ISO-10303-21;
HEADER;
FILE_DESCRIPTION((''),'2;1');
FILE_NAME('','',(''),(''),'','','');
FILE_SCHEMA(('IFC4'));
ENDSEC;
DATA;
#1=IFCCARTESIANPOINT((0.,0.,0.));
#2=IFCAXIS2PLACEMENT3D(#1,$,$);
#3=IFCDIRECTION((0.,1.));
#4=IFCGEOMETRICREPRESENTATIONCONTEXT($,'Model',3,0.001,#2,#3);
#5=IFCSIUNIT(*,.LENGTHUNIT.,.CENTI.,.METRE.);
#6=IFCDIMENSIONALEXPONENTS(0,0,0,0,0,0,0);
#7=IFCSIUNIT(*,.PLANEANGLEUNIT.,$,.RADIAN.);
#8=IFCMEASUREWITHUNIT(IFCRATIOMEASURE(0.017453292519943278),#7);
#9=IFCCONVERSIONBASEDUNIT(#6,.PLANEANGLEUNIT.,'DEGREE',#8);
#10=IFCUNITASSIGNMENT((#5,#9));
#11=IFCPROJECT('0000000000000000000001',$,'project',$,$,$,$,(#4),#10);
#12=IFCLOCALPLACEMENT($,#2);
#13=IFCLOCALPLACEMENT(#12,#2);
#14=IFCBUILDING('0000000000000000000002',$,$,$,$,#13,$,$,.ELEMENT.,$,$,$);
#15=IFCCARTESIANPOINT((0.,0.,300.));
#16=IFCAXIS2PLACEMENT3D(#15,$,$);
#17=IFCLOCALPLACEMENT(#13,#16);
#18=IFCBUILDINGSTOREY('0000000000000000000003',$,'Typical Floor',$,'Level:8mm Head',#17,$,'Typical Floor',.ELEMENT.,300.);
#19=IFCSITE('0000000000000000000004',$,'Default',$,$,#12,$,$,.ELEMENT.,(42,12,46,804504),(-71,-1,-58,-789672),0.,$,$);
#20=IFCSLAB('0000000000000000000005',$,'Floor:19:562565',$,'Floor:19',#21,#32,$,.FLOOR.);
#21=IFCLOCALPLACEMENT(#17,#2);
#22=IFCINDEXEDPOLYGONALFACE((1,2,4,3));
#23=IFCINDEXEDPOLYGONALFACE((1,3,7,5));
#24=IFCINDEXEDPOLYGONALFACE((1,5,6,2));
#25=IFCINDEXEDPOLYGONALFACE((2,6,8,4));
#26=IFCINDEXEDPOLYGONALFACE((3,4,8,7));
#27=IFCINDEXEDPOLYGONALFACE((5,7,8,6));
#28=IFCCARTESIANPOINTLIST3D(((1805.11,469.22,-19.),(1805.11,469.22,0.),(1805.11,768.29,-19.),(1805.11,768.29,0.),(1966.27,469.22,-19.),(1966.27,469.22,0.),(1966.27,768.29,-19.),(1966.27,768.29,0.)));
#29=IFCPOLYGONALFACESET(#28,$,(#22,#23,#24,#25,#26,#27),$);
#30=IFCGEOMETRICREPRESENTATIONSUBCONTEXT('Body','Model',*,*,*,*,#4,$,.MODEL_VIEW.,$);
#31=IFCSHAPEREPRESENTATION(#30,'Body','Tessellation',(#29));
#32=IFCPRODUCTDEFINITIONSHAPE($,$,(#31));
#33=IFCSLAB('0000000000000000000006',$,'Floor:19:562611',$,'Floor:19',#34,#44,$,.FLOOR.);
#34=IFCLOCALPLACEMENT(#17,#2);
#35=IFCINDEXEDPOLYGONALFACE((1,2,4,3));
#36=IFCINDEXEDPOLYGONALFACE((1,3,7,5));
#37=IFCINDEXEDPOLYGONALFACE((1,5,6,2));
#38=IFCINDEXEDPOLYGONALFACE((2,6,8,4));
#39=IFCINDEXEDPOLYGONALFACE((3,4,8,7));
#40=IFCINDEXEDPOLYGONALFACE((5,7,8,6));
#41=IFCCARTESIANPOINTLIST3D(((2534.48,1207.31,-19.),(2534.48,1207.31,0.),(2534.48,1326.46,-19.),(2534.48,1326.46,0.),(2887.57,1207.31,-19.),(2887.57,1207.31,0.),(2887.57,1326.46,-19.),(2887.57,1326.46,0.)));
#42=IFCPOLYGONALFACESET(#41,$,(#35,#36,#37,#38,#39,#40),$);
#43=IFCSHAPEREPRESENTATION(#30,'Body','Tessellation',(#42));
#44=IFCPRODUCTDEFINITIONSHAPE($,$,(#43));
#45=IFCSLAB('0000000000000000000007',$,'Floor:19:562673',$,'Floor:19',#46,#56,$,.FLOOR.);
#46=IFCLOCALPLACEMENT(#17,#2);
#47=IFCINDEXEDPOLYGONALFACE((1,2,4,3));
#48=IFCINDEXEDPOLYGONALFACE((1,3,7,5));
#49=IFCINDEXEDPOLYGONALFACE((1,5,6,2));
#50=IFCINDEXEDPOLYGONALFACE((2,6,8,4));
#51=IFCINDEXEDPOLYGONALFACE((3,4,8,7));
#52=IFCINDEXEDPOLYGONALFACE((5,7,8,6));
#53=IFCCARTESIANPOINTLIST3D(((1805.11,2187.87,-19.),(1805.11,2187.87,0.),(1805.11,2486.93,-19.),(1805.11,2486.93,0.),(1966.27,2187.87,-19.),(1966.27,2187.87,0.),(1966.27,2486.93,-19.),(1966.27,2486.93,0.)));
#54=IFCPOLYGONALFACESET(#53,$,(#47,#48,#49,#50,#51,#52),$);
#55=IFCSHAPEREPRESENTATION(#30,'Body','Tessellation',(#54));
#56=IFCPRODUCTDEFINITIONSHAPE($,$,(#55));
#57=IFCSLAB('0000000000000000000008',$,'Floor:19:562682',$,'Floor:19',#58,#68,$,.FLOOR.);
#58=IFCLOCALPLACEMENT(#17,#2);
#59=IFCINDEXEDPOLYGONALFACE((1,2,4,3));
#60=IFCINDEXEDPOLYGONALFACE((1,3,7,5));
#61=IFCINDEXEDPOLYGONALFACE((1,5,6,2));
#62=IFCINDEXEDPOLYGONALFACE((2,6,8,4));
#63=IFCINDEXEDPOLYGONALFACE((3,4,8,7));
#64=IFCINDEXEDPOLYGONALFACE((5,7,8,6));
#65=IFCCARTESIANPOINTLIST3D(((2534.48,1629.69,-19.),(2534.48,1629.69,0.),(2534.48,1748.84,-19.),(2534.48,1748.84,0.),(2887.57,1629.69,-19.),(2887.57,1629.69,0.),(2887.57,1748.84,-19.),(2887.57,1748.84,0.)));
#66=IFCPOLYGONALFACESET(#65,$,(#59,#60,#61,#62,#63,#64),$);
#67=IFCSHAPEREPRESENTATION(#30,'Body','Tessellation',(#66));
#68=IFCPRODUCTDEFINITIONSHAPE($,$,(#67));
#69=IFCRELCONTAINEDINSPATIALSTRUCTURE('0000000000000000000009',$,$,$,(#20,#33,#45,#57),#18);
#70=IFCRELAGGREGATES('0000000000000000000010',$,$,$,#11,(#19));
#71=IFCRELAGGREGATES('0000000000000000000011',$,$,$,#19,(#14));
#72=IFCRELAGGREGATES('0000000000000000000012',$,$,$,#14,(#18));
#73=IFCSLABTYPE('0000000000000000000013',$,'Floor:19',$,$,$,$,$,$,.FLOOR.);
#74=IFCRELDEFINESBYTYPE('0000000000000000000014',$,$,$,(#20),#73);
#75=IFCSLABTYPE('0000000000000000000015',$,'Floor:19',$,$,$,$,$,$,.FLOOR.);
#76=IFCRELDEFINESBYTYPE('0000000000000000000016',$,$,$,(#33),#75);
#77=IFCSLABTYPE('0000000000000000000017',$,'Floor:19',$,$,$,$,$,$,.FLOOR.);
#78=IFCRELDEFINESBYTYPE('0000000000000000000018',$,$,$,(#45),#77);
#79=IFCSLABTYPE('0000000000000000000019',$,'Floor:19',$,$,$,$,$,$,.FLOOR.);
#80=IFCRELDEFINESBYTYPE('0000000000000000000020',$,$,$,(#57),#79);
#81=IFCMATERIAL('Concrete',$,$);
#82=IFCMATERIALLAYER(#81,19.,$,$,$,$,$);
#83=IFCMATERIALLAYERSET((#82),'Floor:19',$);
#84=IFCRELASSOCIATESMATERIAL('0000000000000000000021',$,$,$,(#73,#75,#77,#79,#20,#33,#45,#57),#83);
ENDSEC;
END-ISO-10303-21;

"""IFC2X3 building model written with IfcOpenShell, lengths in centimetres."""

from ifc_helpers import new_model, entity, si_unit, converted_unit, direction, frame, frame_2d, origin, place, context, subcontext, project, spatial, rectangle, extrude, material, layer, layer_set, layer_usage, type_object, element, save


model = new_model("IFC2X3")

# Units and contexts
model_context = context("Model", 3, precision=0.001, world=origin(), true_north=direction((0.0, 1.0)))
body_context = subcontext(model_context, "Body", "Model", "MODEL_VIEW")
ifc_project = project(units=[si_unit("LENGTHUNIT", "METRE", prefix="CENTI"), converted_unit("PLANEANGLEUNIT", "DEGREE", entity("IfcRatioMeasure", 0.017453292519943278), si_unit("PLANEANGLEUNIT", "RADIAN"), dimensions=[0, 0, 0, 0, 0, 0, 0])], contexts=[model_context])

# Site, building, storey
site_placement = place(None, origin())
site = spatial("IfcSite", under=ifc_project, at=site_placement, Name="Default", CompositionType="ELEMENT", RefLatitude=(42, 12, 46, 804504), RefLongitude=(-71, -1, -58, -789672), RefElevation=0.0)
building_placement = place(site_placement, origin())
building = spatial("IfcBuilding", under=site, at=building_placement, CompositionType="ELEMENT")
storey_placement = place(building_placement, frame((0.0, 0.0, 300.0)))
storey = spatial("IfcBuildingStorey", under=building, at=storey_placement, Name="Typical Floor", ObjectType="Level:8mm Head", LongName="Typical Floor", CompositionType="ELEMENT", Elevation=300.0)

# Shared definitions
ifc_material = material(Name="Concrete")

# Slabs
ifc_layer = layer(ifc_material, 19.0)
ifc_layer_set = layer_set([ifc_layer], Name="Floor:19")
ifc_layer_usage_1 = layer_usage(ifc_layer_set, "AXIS3", "POSITIVE", 0.0)
slab_type_1 = type_object("IfcSlabType", Name="Floor:19", PredefinedType="FLOOR", material=ifc_layer_set)
slab_1_placement = place(storey_placement, origin())
element("IfcSlab", 1, at=slab_1_placement, inside=storey, type_object=slab_type_1, material=ifc_layer_usage_1, Name="Floor:19:562565", ObjectType="Floor:19", PredefinedType="FLOOR", context=body_context, shape_type="SweptSolid", body=[
    extrude(rectangle(XDim=299.06, YDim=161.15, at=frame_2d((0.0, 0.0), x_axis=(1.0, 0.0))), frame((1885.69, 618.75, 0.0), z_axis=(0.0, 0.0, -1.0), x_axis=(0.0, 1.0, 0.0)), (0.0, 0.0, 1.0), 19.0),
])
ifc_layer_usage_2 = layer_usage(ifc_layer_set, "AXIS3", "POSITIVE", 0.0)
slab_type_2 = type_object("IfcSlabType", Name="Floor:19", PredefinedType="FLOOR", material=ifc_layer_set)
slab_2_placement = place(storey_placement, origin())
element("IfcSlab", 2, at=slab_2_placement, inside=storey, type_object=slab_type_2, material=ifc_layer_usage_2, Name="Floor:19:562611", ObjectType="Floor:19", PredefinedType="FLOOR", context=body_context, shape_type="SweptSolid", body=[
    extrude(rectangle(XDim=119.14, YDim=353.09, at=frame_2d((0.0, 0.0), x_axis=(1.0, 0.0))), frame((2711.03, 1266.88, 0.0), z_axis=(0.0, 0.0, -1.0), x_axis=(0.0, 1.0, 0.0)), (0.0, 0.0, 1.0), 19.0),
])
ifc_layer_usage_3 = layer_usage(ifc_layer_set, "AXIS3", "POSITIVE", 0.0)
slab_type_3 = type_object("IfcSlabType", Name="Floor:19", PredefinedType="FLOOR", material=ifc_layer_set)
slab_3_placement = place(storey_placement, origin())
element("IfcSlab", 3, at=slab_3_placement, inside=storey, type_object=slab_type_3, material=ifc_layer_usage_3, Name="Floor:19:562673", ObjectType="Floor:19", PredefinedType="FLOOR", context=body_context, shape_type="SweptSolid", body=[
    extrude(rectangle(XDim=299.06, YDim=161.15, at=frame_2d((0.0, 0.0), x_axis=(1.0, 0.0))), frame((1885.69, 2337.4, 0.0), z_axis=(0.0, 0.0, -1.0), x_axis=(0.0, 1.0, 0.0)), (0.0, 0.0, 1.0), 19.0),
])
ifc_layer_usage_4 = layer_usage(ifc_layer_set, "AXIS3", "POSITIVE", 0.0)
slab_type_4 = type_object("IfcSlabType", Name="Floor:19", PredefinedType="FLOOR", material=ifc_layer_set)
slab_4_placement = place(storey_placement, origin())
element("IfcSlab", 4, at=slab_4_placement, inside=storey, type_object=slab_type_4, material=ifc_layer_usage_4, Name="Floor:19:562682", ObjectType="Floor:19", PredefinedType="FLOOR", context=body_context, shape_type="SweptSolid", body=[
    extrude(rectangle(XDim=119.14, YDim=353.09, at=frame_2d((0.0, 0.0), x_axis=(1.0, 0.0))), frame((2711.03, 1689.27, 0.0), z_axis=(0.0, 0.0, -1.0), x_axis=(0.0, 1.0, 0.0)), (0.0, 0.0, 1.0), 19.0),
])

save(model, "model.ifc")
